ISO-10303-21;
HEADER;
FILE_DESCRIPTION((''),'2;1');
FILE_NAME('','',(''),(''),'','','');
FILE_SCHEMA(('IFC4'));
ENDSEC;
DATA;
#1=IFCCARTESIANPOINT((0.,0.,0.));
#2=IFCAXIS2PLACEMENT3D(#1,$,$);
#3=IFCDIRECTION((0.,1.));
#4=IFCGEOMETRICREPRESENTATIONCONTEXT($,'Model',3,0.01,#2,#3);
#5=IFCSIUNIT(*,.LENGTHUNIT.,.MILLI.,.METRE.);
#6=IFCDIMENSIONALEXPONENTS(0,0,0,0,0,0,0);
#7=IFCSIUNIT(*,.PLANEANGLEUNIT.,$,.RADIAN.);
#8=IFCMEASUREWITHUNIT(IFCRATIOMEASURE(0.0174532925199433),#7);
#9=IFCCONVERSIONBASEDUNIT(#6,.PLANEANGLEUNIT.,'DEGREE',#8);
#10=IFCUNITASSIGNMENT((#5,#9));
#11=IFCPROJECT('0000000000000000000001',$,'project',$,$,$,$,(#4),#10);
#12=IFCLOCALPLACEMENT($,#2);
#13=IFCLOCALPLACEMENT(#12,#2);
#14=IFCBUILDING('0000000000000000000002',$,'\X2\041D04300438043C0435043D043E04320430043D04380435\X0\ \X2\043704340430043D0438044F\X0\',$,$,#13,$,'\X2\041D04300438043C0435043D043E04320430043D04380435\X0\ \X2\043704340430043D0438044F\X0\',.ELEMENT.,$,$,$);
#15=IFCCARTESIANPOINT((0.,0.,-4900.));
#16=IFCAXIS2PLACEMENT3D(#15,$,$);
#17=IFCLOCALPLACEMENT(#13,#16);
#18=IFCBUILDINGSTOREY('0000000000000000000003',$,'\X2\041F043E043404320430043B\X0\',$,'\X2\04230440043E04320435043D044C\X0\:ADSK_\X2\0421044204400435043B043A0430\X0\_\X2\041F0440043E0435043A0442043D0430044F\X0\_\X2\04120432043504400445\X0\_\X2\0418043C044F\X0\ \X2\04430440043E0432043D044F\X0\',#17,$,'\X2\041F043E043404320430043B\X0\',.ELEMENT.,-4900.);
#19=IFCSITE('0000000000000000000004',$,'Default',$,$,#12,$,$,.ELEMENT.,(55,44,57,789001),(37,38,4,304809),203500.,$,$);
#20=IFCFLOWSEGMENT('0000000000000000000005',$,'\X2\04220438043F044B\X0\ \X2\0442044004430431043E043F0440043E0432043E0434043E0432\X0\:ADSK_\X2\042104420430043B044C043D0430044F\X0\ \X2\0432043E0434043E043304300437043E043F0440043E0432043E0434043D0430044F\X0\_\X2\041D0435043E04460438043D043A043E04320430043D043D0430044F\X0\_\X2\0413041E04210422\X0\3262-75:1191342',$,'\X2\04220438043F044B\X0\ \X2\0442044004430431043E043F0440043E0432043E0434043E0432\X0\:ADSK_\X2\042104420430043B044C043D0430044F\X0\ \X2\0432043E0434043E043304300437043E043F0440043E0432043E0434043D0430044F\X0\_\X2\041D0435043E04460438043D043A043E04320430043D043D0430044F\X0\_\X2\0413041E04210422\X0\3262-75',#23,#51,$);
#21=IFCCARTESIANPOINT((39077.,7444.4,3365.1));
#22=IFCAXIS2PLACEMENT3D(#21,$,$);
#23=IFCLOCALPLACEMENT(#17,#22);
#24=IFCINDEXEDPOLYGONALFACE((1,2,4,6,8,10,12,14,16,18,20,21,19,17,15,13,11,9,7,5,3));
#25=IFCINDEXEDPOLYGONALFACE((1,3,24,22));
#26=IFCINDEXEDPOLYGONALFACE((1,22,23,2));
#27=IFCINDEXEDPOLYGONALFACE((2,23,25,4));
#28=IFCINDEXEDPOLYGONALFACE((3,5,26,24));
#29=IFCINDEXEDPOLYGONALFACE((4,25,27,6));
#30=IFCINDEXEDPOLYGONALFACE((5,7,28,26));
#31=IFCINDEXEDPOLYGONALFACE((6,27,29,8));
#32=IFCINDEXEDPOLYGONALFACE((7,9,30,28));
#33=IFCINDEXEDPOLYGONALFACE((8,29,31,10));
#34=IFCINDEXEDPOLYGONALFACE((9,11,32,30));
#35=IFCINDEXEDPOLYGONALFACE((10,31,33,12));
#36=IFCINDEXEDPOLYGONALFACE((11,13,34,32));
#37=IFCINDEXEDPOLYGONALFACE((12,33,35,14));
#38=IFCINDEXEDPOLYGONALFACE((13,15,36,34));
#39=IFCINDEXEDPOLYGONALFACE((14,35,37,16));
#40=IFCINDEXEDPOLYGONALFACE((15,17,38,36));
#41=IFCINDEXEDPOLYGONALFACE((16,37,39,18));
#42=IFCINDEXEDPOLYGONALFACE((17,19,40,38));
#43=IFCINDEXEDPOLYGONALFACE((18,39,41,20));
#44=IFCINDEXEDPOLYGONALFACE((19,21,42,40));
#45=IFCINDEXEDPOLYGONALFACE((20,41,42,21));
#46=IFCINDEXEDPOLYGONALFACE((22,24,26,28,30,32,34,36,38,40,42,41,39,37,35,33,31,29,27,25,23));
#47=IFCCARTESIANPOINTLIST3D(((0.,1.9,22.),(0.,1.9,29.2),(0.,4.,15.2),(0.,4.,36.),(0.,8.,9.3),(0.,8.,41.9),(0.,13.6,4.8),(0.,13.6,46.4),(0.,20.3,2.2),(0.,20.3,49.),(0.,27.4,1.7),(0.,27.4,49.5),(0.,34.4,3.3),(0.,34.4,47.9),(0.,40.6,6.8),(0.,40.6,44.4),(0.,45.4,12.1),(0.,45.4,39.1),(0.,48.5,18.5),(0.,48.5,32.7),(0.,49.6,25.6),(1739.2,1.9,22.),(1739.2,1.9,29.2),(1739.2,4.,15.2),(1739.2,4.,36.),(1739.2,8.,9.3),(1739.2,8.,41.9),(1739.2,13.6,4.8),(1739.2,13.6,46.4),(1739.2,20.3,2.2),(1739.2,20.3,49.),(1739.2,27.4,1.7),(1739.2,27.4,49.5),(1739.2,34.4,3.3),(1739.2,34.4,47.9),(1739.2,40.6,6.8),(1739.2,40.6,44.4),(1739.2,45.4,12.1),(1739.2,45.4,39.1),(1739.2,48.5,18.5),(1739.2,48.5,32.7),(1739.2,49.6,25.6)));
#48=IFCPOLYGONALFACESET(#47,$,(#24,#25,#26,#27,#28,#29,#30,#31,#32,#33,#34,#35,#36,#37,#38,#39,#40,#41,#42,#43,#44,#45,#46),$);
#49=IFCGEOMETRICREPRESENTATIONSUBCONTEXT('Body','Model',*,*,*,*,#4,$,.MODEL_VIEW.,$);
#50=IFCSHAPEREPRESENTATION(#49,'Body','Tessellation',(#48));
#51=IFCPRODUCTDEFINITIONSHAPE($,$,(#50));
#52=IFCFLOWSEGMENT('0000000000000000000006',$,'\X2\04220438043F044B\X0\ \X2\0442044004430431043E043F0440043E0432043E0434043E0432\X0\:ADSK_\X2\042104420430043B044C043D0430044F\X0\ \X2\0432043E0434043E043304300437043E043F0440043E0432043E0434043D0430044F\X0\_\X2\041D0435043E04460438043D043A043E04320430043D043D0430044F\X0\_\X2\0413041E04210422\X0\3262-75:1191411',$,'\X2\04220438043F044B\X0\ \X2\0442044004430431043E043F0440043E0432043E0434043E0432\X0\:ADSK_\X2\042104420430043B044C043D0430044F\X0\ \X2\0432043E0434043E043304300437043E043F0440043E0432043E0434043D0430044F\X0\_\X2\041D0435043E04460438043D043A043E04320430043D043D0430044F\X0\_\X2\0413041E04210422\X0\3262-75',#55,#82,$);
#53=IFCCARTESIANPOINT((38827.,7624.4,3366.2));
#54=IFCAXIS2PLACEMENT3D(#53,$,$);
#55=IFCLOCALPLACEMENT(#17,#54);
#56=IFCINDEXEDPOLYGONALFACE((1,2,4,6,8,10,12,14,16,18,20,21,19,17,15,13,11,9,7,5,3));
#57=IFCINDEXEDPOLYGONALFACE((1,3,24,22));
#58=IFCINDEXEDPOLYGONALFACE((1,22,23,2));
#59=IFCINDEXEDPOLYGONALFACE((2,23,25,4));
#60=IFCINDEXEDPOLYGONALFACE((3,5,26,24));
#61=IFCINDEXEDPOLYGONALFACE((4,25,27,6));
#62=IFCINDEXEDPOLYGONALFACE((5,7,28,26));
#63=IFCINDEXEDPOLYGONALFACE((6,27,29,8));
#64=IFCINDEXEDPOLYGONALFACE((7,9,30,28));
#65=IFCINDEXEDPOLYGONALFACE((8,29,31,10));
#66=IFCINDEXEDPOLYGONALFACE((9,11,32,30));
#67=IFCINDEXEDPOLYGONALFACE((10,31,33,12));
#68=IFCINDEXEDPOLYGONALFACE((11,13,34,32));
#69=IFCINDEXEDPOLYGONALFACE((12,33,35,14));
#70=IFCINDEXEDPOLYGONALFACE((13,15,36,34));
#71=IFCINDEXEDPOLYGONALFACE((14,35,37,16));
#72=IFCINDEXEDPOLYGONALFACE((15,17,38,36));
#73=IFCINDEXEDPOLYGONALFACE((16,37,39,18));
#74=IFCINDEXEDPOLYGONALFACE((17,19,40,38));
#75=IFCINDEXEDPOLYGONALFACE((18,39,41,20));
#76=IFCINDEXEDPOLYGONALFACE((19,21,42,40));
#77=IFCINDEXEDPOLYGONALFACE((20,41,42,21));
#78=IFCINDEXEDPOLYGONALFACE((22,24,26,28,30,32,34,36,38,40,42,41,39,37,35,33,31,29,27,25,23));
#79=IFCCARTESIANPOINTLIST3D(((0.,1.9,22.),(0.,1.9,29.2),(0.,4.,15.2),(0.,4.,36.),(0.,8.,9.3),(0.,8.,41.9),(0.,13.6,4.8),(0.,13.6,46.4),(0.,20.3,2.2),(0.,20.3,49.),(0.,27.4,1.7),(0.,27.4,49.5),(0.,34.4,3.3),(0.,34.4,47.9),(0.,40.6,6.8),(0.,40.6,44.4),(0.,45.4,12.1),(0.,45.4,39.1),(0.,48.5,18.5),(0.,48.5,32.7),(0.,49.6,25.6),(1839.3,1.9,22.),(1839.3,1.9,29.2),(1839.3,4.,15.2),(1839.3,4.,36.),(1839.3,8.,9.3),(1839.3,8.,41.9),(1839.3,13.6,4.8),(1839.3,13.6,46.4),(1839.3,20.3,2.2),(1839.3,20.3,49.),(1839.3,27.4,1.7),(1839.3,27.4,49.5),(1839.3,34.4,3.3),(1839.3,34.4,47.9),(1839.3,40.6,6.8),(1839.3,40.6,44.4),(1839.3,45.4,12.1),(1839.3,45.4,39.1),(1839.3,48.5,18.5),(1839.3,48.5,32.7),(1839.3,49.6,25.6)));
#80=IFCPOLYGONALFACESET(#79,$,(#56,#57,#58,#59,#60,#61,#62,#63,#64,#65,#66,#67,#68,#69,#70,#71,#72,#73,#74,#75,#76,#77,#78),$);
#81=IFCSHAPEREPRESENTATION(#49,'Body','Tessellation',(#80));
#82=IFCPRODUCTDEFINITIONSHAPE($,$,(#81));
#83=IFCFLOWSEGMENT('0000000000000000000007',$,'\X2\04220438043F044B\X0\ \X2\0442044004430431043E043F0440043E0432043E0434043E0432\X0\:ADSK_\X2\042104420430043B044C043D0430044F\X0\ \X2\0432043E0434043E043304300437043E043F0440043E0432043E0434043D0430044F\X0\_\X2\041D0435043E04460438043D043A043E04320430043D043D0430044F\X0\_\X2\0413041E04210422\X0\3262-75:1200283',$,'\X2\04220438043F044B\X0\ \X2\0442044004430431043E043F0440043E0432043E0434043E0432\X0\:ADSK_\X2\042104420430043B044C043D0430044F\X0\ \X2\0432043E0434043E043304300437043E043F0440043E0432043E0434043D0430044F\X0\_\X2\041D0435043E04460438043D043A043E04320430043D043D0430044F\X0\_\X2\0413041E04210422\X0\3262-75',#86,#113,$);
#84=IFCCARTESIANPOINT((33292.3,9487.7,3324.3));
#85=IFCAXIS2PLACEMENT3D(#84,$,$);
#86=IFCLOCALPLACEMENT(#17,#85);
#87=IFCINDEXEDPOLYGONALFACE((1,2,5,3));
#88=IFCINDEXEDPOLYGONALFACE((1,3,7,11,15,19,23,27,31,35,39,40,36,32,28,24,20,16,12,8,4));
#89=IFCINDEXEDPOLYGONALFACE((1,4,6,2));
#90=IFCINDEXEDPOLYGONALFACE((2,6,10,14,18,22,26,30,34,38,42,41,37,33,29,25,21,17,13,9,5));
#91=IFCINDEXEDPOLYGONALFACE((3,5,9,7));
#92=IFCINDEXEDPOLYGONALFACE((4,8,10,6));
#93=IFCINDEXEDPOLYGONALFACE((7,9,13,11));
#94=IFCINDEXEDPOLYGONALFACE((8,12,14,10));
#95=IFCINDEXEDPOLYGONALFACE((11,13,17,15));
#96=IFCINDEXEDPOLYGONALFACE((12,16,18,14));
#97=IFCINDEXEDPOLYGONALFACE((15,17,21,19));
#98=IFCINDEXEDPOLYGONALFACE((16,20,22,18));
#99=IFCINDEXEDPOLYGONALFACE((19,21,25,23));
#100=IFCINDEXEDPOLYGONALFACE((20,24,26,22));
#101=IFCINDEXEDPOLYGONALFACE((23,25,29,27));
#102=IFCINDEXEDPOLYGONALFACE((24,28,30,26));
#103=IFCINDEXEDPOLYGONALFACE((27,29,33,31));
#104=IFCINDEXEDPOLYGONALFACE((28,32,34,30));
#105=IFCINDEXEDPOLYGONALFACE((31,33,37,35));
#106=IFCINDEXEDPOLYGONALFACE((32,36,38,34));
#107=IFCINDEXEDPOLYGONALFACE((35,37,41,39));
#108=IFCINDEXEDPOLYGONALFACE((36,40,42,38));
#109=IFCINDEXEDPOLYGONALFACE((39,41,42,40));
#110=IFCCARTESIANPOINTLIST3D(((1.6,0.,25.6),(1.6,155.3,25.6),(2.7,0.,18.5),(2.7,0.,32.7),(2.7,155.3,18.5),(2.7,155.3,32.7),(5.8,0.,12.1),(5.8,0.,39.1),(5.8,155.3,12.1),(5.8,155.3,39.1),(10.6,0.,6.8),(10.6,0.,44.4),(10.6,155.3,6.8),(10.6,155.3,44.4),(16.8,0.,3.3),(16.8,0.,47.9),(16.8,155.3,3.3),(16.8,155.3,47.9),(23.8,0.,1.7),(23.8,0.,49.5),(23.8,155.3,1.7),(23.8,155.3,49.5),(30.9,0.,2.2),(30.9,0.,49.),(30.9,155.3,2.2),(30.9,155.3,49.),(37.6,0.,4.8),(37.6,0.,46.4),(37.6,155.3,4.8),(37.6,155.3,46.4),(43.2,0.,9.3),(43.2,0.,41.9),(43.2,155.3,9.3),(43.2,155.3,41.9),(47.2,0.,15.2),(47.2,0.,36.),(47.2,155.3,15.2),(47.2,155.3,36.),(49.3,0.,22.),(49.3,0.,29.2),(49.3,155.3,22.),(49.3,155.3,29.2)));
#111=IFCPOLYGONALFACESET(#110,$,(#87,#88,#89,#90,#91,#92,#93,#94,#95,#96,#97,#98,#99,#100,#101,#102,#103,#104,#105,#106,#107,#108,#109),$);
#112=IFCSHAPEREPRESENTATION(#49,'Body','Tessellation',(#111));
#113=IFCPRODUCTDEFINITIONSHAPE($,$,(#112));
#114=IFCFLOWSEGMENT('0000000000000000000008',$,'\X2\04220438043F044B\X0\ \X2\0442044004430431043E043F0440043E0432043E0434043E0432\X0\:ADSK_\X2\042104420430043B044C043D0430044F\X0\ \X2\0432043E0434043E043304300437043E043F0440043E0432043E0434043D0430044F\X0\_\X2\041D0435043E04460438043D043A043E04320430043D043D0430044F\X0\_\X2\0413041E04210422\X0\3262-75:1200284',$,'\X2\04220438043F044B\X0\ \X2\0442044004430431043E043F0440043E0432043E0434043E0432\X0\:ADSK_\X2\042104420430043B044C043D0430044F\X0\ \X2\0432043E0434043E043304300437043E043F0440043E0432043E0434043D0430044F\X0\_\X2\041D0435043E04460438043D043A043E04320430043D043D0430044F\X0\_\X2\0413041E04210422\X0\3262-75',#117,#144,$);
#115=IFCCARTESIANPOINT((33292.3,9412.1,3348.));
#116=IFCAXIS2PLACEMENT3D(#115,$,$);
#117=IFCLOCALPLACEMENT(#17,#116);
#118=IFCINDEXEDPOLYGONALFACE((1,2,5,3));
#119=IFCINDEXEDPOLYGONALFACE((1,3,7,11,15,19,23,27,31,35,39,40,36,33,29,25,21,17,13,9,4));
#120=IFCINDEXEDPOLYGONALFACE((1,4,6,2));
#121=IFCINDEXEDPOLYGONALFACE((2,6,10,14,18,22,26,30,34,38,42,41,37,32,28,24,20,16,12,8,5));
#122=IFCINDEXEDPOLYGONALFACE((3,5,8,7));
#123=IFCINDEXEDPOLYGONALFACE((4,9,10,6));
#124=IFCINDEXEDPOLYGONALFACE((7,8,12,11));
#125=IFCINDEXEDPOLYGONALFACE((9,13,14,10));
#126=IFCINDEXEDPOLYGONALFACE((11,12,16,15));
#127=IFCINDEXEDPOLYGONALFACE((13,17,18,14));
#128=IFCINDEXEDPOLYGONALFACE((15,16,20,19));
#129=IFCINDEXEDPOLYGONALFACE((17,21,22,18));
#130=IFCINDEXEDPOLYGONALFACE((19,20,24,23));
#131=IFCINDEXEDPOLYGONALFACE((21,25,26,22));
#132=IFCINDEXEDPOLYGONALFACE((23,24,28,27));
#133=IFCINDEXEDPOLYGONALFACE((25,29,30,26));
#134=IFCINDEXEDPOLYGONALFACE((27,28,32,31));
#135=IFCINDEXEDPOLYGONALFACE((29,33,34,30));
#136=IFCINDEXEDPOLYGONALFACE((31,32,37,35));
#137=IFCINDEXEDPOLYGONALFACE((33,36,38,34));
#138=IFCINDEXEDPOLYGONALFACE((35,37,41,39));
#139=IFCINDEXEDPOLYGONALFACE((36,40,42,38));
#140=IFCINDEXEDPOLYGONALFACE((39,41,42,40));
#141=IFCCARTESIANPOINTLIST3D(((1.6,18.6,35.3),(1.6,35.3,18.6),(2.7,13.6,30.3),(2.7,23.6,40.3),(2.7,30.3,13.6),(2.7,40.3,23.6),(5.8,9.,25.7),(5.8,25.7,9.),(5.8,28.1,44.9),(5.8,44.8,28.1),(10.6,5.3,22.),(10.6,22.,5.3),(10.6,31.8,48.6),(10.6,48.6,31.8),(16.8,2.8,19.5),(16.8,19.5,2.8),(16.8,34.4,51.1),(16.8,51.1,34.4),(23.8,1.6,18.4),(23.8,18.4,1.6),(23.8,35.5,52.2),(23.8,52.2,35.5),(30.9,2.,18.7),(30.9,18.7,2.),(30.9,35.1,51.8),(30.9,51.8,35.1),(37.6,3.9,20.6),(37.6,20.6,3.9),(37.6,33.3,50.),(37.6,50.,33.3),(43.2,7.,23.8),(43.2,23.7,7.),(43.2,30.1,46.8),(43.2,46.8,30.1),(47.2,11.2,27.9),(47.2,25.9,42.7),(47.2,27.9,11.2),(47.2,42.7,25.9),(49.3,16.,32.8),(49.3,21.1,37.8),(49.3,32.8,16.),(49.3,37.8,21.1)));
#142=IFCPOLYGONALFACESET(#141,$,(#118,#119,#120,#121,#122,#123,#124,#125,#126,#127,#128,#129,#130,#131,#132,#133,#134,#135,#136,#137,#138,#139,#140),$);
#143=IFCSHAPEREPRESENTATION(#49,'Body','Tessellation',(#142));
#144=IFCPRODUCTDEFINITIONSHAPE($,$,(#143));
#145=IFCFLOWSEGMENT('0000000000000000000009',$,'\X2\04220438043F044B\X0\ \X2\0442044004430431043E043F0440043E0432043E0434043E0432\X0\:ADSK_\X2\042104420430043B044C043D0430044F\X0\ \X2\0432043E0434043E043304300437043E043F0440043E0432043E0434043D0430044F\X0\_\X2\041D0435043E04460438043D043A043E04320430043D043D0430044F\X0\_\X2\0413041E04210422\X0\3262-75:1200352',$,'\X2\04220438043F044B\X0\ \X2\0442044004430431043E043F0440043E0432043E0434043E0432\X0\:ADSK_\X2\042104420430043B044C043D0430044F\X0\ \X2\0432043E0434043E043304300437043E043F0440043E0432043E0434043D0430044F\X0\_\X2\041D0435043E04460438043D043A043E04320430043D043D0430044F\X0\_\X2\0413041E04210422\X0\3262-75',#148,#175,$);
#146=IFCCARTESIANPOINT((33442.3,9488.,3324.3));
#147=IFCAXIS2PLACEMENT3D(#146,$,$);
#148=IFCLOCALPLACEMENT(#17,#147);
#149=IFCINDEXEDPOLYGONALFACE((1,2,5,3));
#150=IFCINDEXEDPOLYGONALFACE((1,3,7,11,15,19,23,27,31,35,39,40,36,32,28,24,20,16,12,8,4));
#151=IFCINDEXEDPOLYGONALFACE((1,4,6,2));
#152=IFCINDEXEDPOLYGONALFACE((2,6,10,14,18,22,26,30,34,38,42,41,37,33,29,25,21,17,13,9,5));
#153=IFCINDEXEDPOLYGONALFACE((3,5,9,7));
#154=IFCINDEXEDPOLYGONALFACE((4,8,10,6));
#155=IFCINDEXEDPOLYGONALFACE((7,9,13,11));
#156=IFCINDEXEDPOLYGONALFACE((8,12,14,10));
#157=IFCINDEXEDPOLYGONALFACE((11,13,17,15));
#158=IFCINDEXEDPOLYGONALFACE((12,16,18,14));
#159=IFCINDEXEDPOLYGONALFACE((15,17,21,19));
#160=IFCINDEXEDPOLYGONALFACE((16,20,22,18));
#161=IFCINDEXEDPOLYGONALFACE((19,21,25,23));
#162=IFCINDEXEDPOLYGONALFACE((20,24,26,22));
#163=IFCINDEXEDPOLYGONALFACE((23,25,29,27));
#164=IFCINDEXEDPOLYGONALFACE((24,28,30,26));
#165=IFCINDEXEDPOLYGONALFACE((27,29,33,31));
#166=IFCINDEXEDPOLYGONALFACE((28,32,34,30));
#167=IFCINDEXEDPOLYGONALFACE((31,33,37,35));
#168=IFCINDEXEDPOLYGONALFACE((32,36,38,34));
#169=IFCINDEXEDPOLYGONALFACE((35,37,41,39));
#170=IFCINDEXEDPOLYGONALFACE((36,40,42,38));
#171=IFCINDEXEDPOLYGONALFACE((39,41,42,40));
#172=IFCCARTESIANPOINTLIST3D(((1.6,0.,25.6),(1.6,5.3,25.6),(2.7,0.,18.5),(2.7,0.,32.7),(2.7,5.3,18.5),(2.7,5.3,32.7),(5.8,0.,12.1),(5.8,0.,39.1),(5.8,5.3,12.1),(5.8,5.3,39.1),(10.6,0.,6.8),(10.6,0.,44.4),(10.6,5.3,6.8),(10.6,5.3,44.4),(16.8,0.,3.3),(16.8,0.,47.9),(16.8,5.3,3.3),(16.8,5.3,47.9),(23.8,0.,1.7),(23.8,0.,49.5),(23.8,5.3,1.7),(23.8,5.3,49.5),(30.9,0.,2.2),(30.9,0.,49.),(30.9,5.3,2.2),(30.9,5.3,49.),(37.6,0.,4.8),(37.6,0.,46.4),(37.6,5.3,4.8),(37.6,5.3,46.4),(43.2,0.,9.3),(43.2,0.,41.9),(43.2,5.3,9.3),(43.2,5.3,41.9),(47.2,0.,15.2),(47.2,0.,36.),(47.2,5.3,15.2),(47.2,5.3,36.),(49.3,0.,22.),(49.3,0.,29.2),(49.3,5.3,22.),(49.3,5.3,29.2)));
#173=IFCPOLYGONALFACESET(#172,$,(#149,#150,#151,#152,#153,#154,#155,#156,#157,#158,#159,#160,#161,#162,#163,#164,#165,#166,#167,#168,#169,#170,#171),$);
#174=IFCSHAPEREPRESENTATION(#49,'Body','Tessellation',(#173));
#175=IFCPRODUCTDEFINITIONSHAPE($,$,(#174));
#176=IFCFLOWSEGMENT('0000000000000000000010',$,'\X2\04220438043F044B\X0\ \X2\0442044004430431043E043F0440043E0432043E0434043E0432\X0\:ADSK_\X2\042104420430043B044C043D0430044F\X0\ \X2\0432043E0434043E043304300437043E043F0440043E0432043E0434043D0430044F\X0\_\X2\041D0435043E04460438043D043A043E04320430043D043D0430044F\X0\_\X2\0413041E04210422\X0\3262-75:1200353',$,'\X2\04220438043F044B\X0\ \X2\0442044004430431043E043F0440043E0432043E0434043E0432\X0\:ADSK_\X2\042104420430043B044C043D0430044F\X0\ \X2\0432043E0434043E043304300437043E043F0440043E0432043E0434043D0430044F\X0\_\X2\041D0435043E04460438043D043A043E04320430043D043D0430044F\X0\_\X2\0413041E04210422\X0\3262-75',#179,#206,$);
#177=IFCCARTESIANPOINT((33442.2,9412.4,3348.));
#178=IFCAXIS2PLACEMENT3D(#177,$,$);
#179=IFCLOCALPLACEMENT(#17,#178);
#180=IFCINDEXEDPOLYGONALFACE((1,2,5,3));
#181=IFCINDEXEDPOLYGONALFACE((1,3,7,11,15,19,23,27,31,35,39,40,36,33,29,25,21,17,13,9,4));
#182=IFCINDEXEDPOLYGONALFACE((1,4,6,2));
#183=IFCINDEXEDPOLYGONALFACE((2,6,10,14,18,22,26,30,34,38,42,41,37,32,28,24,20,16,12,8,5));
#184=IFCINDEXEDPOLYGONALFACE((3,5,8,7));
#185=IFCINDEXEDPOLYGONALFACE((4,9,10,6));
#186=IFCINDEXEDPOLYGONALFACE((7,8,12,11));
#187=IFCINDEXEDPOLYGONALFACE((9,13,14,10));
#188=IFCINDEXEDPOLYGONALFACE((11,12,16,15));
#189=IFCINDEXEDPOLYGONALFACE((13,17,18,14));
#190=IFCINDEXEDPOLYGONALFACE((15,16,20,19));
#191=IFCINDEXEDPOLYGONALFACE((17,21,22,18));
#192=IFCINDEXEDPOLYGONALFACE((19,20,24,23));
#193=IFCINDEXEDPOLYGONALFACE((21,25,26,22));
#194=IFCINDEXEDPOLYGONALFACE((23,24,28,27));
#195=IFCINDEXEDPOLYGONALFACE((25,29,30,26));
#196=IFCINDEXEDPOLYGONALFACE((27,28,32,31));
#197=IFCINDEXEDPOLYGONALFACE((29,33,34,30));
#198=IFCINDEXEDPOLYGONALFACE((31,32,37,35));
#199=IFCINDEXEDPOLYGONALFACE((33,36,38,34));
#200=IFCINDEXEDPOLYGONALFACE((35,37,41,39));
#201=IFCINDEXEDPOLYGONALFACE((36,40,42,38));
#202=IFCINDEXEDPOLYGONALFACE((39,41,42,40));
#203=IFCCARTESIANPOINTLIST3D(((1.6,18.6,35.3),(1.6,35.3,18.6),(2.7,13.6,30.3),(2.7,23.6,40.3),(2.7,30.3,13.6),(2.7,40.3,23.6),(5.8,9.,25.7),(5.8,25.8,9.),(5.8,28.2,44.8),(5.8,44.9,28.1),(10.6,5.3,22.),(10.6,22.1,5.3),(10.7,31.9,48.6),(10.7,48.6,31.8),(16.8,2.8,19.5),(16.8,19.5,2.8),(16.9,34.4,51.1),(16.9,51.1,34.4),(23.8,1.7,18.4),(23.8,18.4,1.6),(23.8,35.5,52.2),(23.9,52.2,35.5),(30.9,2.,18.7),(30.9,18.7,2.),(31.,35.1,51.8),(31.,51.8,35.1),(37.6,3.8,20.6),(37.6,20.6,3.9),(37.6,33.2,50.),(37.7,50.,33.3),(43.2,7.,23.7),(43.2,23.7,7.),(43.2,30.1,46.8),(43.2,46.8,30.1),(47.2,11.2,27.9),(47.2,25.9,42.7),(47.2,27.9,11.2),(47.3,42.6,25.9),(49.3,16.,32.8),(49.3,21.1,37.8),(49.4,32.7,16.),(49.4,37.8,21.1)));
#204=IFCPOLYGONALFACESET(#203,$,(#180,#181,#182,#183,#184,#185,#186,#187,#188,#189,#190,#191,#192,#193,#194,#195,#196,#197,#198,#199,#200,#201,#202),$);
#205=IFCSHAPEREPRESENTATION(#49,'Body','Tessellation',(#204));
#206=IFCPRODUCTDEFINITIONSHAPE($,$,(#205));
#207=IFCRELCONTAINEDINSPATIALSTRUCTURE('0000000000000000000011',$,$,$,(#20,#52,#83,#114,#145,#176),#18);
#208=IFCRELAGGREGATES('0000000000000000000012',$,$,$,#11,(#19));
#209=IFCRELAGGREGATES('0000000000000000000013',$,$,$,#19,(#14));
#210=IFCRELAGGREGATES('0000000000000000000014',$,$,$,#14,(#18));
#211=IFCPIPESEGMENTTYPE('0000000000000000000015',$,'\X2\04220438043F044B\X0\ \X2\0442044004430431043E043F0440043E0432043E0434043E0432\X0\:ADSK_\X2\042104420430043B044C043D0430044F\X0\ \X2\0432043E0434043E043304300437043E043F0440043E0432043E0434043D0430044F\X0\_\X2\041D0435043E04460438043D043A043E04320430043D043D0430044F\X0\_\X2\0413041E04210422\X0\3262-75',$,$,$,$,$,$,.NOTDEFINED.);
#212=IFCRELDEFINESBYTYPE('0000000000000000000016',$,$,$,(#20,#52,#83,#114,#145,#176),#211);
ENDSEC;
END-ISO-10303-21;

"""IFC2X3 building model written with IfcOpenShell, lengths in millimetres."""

from ifc_helpers import new_model, entity, si_unit, converted_unit, direction, frame, origin, origin_2d_with_axis, place, context, subcontext, project, spatial, circle, extrude, type_object, element, save


model = new_model("IFC2X3")

# Units and contexts
model_context = context("Model", 3, precision=0.01, world=origin(), true_north=direction((0.0, 1.0)))
body_context = subcontext(model_context, "Body", "Model", "MODEL_VIEW")
ifc_project = project(units=[si_unit("LENGTHUNIT", "METRE", prefix="MILLI"), converted_unit("PLANEANGLEUNIT", "DEGREE", entity("IfcRatioMeasure", 0.0174532925199433), si_unit("PLANEANGLEUNIT", "RADIAN"), dimensions=[0, 0, 0, 0, 0, 0, 0])], contexts=[model_context])

# Site, building, storey
site_placement = place(None, origin())
site = spatial("IfcSite", under=ifc_project, at=site_placement, Name="Default", CompositionType="ELEMENT", RefLatitude=(55, 44, 57, 789001), RefLongitude=(37, 38, 4, 304809), RefElevation=203500.0)
building_placement = place(site_placement, origin())
building = spatial("IfcBuilding", under=site, at=building_placement, Name="Наименование здания", LongName="Наименование здания", CompositionType="ELEMENT")
storey_placement = place(building_placement, frame((0.0, 0.0, -4900.0)))
storey = spatial("IfcBuildingStorey", under=building, at=storey_placement, Name="Подвал", ObjectType="Уровень:ADSK_Стрелка_Проектная_Вверх_Имя уровня", LongName="Подвал", CompositionType="ELEMENT", Elevation=-4900.0)

# Flow segments
pipe_segment_type_1 = type_object("IfcPipeSegmentType", Name="Типы трубопроводов:ADSK_Стальная водогазопроводная_Неоцинкованная_ГОСТ3262-75", PredefinedType="NOTDEFINED")
flow_segment_1_placement = place(storey_placement, frame((39077.0, 7444.4, 3365.1)))
element("IfcFlowSegment", 1, at=flow_segment_1_placement, inside=storey, type_object=pipe_segment_type_1, Name="Типы трубопроводов:ADSK_Стальная водогазопроводная_Неоцинкованная_ГОСТ3262-75:1191342", ObjectType="Типы трубопроводов:ADSK_Стальная водогазопроводная_Неоцинкованная_ГОСТ3262-75", context=body_context, shape_type="SweptSolid", body=[
    extrude(circle(Radius=24.0, at=origin_2d_with_axis()), frame((0.0, 25.6, 25.6), z_axis=(1.0, 0.0, 0.0), x_axis=(0.0, 1.0, 0.0)), (0.0, 0.0, 1.0), 1739.2),
])
flow_segment_2_placement = place(storey_placement, frame((38827.0, 7624.4, 3366.2)))
element("IfcFlowSegment", 2, at=flow_segment_2_placement, inside=storey, type_object=pipe_segment_type_1, Name="Типы трубопроводов:ADSK_Стальная водогазопроводная_Неоцинкованная_ГОСТ3262-75:1191411", ObjectType="Типы трубопроводов:ADSK_Стальная водогазопроводная_Неоцинкованная_ГОСТ3262-75", context=body_context, shape_type="SweptSolid", body=[
    extrude(circle(Radius=24.0, at=origin_2d_with_axis()), frame((0.0, 25.6, 25.6), z_axis=(1.0, 0.0, 0.0), x_axis=(0.0, 1.0, 0.0)), (0.0, 0.0, 1.0), 1839.3),
])
flow_segment_3_placement = place(storey_placement, frame((33292.3, 9487.7, 3324.3)))
element("IfcFlowSegment", 3, at=flow_segment_3_placement, inside=storey, type_object=pipe_segment_type_1, Name="Типы трубопроводов:ADSK_Стальная водогазопроводная_Неоцинкованная_ГОСТ3262-75:1200283", ObjectType="Типы трубопроводов:ADSK_Стальная водогазопроводная_Неоцинкованная_ГОСТ3262-75", context=body_context, shape_type="SweptSolid", body=[
    extrude(circle(Radius=24.0, at=origin_2d_with_axis()), frame((25.6, 0.0, 25.6), z_axis=(0.0, 1.0, 0.0), x_axis=(-1.0, 0.0, 0.0)), (0.0, 0.0, 1.0), 155.3),
])
flow_segment_4_placement = place(storey_placement, frame((33292.3, 9412.1, 3348.0)))
element("IfcFlowSegment", 4, at=flow_segment_4_placement, inside=storey, type_object=pipe_segment_type_1, Name="Типы трубопроводов:ADSK_Стальная водогазопроводная_Неоцинкованная_ГОСТ3262-75:1200284", ObjectType="Типы трубопроводов:ADSK_Стальная водогазопроводная_Неоцинкованная_ГОСТ3262-75", context=body_context, shape_type="SweptSolid", body=[
    extrude(circle(Radius=24.0, at=origin_2d_with_axis()), frame((25.6, 35.3, 18.6), z_axis=(0.0, -0.707107, 0.707107), x_axis=(-1.0, 0.0, 0.0)), (0.0, 0.0, 1.0), 23.7),
])
flow_segment_5_placement = place(storey_placement, frame((33442.3, 9488.0, 3324.3)))
element("IfcFlowSegment", 5, at=flow_segment_5_placement, inside=storey, type_object=pipe_segment_type_1, Name="Типы трубопроводов:ADSK_Стальная водогазопроводная_Неоцинкованная_ГОСТ3262-75:1200352", ObjectType="Типы трубопроводов:ADSK_Стальная водогазопроводная_Неоцинкованная_ГОСТ3262-75", context=body_context, shape_type="SweptSolid", body=[
    extrude(circle(Radius=24.0, at=origin_2d_with_axis()), frame((25.6, 0.0, 25.6), z_axis=(0.0, 1.0, 0.0), x_axis=(-1.0, 0.0, 0.0)), (0.0, 0.0, 1.0), 5.3),
])
flow_segment_6_placement = place(storey_placement, frame((33442.2, 9412.4, 3348.0)))
element("IfcFlowSegment", 6, at=flow_segment_6_placement, inside=storey, type_object=pipe_segment_type_1, Name="Типы трубопроводов:ADSK_Стальная водогазопроводная_Неоцинкованная_ГОСТ3262-75:1200353", ObjectType="Типы трубопроводов:ADSK_Стальная водогазопроводная_Неоцинкованная_ГОСТ3262-75", context=body_context, shape_type="SweptSolid", body=[
    extrude(circle(Radius=24.0, at=origin_2d_with_axis()), frame((25.6, 18.6, 35.3), z_axis=(0.001414, 0.707105, -0.707107), x_axis=(-0.999998, 0.002, 0.0)), (0.0, 0.0, 1.0), 23.7),
])

save(model, "model.ifc")
